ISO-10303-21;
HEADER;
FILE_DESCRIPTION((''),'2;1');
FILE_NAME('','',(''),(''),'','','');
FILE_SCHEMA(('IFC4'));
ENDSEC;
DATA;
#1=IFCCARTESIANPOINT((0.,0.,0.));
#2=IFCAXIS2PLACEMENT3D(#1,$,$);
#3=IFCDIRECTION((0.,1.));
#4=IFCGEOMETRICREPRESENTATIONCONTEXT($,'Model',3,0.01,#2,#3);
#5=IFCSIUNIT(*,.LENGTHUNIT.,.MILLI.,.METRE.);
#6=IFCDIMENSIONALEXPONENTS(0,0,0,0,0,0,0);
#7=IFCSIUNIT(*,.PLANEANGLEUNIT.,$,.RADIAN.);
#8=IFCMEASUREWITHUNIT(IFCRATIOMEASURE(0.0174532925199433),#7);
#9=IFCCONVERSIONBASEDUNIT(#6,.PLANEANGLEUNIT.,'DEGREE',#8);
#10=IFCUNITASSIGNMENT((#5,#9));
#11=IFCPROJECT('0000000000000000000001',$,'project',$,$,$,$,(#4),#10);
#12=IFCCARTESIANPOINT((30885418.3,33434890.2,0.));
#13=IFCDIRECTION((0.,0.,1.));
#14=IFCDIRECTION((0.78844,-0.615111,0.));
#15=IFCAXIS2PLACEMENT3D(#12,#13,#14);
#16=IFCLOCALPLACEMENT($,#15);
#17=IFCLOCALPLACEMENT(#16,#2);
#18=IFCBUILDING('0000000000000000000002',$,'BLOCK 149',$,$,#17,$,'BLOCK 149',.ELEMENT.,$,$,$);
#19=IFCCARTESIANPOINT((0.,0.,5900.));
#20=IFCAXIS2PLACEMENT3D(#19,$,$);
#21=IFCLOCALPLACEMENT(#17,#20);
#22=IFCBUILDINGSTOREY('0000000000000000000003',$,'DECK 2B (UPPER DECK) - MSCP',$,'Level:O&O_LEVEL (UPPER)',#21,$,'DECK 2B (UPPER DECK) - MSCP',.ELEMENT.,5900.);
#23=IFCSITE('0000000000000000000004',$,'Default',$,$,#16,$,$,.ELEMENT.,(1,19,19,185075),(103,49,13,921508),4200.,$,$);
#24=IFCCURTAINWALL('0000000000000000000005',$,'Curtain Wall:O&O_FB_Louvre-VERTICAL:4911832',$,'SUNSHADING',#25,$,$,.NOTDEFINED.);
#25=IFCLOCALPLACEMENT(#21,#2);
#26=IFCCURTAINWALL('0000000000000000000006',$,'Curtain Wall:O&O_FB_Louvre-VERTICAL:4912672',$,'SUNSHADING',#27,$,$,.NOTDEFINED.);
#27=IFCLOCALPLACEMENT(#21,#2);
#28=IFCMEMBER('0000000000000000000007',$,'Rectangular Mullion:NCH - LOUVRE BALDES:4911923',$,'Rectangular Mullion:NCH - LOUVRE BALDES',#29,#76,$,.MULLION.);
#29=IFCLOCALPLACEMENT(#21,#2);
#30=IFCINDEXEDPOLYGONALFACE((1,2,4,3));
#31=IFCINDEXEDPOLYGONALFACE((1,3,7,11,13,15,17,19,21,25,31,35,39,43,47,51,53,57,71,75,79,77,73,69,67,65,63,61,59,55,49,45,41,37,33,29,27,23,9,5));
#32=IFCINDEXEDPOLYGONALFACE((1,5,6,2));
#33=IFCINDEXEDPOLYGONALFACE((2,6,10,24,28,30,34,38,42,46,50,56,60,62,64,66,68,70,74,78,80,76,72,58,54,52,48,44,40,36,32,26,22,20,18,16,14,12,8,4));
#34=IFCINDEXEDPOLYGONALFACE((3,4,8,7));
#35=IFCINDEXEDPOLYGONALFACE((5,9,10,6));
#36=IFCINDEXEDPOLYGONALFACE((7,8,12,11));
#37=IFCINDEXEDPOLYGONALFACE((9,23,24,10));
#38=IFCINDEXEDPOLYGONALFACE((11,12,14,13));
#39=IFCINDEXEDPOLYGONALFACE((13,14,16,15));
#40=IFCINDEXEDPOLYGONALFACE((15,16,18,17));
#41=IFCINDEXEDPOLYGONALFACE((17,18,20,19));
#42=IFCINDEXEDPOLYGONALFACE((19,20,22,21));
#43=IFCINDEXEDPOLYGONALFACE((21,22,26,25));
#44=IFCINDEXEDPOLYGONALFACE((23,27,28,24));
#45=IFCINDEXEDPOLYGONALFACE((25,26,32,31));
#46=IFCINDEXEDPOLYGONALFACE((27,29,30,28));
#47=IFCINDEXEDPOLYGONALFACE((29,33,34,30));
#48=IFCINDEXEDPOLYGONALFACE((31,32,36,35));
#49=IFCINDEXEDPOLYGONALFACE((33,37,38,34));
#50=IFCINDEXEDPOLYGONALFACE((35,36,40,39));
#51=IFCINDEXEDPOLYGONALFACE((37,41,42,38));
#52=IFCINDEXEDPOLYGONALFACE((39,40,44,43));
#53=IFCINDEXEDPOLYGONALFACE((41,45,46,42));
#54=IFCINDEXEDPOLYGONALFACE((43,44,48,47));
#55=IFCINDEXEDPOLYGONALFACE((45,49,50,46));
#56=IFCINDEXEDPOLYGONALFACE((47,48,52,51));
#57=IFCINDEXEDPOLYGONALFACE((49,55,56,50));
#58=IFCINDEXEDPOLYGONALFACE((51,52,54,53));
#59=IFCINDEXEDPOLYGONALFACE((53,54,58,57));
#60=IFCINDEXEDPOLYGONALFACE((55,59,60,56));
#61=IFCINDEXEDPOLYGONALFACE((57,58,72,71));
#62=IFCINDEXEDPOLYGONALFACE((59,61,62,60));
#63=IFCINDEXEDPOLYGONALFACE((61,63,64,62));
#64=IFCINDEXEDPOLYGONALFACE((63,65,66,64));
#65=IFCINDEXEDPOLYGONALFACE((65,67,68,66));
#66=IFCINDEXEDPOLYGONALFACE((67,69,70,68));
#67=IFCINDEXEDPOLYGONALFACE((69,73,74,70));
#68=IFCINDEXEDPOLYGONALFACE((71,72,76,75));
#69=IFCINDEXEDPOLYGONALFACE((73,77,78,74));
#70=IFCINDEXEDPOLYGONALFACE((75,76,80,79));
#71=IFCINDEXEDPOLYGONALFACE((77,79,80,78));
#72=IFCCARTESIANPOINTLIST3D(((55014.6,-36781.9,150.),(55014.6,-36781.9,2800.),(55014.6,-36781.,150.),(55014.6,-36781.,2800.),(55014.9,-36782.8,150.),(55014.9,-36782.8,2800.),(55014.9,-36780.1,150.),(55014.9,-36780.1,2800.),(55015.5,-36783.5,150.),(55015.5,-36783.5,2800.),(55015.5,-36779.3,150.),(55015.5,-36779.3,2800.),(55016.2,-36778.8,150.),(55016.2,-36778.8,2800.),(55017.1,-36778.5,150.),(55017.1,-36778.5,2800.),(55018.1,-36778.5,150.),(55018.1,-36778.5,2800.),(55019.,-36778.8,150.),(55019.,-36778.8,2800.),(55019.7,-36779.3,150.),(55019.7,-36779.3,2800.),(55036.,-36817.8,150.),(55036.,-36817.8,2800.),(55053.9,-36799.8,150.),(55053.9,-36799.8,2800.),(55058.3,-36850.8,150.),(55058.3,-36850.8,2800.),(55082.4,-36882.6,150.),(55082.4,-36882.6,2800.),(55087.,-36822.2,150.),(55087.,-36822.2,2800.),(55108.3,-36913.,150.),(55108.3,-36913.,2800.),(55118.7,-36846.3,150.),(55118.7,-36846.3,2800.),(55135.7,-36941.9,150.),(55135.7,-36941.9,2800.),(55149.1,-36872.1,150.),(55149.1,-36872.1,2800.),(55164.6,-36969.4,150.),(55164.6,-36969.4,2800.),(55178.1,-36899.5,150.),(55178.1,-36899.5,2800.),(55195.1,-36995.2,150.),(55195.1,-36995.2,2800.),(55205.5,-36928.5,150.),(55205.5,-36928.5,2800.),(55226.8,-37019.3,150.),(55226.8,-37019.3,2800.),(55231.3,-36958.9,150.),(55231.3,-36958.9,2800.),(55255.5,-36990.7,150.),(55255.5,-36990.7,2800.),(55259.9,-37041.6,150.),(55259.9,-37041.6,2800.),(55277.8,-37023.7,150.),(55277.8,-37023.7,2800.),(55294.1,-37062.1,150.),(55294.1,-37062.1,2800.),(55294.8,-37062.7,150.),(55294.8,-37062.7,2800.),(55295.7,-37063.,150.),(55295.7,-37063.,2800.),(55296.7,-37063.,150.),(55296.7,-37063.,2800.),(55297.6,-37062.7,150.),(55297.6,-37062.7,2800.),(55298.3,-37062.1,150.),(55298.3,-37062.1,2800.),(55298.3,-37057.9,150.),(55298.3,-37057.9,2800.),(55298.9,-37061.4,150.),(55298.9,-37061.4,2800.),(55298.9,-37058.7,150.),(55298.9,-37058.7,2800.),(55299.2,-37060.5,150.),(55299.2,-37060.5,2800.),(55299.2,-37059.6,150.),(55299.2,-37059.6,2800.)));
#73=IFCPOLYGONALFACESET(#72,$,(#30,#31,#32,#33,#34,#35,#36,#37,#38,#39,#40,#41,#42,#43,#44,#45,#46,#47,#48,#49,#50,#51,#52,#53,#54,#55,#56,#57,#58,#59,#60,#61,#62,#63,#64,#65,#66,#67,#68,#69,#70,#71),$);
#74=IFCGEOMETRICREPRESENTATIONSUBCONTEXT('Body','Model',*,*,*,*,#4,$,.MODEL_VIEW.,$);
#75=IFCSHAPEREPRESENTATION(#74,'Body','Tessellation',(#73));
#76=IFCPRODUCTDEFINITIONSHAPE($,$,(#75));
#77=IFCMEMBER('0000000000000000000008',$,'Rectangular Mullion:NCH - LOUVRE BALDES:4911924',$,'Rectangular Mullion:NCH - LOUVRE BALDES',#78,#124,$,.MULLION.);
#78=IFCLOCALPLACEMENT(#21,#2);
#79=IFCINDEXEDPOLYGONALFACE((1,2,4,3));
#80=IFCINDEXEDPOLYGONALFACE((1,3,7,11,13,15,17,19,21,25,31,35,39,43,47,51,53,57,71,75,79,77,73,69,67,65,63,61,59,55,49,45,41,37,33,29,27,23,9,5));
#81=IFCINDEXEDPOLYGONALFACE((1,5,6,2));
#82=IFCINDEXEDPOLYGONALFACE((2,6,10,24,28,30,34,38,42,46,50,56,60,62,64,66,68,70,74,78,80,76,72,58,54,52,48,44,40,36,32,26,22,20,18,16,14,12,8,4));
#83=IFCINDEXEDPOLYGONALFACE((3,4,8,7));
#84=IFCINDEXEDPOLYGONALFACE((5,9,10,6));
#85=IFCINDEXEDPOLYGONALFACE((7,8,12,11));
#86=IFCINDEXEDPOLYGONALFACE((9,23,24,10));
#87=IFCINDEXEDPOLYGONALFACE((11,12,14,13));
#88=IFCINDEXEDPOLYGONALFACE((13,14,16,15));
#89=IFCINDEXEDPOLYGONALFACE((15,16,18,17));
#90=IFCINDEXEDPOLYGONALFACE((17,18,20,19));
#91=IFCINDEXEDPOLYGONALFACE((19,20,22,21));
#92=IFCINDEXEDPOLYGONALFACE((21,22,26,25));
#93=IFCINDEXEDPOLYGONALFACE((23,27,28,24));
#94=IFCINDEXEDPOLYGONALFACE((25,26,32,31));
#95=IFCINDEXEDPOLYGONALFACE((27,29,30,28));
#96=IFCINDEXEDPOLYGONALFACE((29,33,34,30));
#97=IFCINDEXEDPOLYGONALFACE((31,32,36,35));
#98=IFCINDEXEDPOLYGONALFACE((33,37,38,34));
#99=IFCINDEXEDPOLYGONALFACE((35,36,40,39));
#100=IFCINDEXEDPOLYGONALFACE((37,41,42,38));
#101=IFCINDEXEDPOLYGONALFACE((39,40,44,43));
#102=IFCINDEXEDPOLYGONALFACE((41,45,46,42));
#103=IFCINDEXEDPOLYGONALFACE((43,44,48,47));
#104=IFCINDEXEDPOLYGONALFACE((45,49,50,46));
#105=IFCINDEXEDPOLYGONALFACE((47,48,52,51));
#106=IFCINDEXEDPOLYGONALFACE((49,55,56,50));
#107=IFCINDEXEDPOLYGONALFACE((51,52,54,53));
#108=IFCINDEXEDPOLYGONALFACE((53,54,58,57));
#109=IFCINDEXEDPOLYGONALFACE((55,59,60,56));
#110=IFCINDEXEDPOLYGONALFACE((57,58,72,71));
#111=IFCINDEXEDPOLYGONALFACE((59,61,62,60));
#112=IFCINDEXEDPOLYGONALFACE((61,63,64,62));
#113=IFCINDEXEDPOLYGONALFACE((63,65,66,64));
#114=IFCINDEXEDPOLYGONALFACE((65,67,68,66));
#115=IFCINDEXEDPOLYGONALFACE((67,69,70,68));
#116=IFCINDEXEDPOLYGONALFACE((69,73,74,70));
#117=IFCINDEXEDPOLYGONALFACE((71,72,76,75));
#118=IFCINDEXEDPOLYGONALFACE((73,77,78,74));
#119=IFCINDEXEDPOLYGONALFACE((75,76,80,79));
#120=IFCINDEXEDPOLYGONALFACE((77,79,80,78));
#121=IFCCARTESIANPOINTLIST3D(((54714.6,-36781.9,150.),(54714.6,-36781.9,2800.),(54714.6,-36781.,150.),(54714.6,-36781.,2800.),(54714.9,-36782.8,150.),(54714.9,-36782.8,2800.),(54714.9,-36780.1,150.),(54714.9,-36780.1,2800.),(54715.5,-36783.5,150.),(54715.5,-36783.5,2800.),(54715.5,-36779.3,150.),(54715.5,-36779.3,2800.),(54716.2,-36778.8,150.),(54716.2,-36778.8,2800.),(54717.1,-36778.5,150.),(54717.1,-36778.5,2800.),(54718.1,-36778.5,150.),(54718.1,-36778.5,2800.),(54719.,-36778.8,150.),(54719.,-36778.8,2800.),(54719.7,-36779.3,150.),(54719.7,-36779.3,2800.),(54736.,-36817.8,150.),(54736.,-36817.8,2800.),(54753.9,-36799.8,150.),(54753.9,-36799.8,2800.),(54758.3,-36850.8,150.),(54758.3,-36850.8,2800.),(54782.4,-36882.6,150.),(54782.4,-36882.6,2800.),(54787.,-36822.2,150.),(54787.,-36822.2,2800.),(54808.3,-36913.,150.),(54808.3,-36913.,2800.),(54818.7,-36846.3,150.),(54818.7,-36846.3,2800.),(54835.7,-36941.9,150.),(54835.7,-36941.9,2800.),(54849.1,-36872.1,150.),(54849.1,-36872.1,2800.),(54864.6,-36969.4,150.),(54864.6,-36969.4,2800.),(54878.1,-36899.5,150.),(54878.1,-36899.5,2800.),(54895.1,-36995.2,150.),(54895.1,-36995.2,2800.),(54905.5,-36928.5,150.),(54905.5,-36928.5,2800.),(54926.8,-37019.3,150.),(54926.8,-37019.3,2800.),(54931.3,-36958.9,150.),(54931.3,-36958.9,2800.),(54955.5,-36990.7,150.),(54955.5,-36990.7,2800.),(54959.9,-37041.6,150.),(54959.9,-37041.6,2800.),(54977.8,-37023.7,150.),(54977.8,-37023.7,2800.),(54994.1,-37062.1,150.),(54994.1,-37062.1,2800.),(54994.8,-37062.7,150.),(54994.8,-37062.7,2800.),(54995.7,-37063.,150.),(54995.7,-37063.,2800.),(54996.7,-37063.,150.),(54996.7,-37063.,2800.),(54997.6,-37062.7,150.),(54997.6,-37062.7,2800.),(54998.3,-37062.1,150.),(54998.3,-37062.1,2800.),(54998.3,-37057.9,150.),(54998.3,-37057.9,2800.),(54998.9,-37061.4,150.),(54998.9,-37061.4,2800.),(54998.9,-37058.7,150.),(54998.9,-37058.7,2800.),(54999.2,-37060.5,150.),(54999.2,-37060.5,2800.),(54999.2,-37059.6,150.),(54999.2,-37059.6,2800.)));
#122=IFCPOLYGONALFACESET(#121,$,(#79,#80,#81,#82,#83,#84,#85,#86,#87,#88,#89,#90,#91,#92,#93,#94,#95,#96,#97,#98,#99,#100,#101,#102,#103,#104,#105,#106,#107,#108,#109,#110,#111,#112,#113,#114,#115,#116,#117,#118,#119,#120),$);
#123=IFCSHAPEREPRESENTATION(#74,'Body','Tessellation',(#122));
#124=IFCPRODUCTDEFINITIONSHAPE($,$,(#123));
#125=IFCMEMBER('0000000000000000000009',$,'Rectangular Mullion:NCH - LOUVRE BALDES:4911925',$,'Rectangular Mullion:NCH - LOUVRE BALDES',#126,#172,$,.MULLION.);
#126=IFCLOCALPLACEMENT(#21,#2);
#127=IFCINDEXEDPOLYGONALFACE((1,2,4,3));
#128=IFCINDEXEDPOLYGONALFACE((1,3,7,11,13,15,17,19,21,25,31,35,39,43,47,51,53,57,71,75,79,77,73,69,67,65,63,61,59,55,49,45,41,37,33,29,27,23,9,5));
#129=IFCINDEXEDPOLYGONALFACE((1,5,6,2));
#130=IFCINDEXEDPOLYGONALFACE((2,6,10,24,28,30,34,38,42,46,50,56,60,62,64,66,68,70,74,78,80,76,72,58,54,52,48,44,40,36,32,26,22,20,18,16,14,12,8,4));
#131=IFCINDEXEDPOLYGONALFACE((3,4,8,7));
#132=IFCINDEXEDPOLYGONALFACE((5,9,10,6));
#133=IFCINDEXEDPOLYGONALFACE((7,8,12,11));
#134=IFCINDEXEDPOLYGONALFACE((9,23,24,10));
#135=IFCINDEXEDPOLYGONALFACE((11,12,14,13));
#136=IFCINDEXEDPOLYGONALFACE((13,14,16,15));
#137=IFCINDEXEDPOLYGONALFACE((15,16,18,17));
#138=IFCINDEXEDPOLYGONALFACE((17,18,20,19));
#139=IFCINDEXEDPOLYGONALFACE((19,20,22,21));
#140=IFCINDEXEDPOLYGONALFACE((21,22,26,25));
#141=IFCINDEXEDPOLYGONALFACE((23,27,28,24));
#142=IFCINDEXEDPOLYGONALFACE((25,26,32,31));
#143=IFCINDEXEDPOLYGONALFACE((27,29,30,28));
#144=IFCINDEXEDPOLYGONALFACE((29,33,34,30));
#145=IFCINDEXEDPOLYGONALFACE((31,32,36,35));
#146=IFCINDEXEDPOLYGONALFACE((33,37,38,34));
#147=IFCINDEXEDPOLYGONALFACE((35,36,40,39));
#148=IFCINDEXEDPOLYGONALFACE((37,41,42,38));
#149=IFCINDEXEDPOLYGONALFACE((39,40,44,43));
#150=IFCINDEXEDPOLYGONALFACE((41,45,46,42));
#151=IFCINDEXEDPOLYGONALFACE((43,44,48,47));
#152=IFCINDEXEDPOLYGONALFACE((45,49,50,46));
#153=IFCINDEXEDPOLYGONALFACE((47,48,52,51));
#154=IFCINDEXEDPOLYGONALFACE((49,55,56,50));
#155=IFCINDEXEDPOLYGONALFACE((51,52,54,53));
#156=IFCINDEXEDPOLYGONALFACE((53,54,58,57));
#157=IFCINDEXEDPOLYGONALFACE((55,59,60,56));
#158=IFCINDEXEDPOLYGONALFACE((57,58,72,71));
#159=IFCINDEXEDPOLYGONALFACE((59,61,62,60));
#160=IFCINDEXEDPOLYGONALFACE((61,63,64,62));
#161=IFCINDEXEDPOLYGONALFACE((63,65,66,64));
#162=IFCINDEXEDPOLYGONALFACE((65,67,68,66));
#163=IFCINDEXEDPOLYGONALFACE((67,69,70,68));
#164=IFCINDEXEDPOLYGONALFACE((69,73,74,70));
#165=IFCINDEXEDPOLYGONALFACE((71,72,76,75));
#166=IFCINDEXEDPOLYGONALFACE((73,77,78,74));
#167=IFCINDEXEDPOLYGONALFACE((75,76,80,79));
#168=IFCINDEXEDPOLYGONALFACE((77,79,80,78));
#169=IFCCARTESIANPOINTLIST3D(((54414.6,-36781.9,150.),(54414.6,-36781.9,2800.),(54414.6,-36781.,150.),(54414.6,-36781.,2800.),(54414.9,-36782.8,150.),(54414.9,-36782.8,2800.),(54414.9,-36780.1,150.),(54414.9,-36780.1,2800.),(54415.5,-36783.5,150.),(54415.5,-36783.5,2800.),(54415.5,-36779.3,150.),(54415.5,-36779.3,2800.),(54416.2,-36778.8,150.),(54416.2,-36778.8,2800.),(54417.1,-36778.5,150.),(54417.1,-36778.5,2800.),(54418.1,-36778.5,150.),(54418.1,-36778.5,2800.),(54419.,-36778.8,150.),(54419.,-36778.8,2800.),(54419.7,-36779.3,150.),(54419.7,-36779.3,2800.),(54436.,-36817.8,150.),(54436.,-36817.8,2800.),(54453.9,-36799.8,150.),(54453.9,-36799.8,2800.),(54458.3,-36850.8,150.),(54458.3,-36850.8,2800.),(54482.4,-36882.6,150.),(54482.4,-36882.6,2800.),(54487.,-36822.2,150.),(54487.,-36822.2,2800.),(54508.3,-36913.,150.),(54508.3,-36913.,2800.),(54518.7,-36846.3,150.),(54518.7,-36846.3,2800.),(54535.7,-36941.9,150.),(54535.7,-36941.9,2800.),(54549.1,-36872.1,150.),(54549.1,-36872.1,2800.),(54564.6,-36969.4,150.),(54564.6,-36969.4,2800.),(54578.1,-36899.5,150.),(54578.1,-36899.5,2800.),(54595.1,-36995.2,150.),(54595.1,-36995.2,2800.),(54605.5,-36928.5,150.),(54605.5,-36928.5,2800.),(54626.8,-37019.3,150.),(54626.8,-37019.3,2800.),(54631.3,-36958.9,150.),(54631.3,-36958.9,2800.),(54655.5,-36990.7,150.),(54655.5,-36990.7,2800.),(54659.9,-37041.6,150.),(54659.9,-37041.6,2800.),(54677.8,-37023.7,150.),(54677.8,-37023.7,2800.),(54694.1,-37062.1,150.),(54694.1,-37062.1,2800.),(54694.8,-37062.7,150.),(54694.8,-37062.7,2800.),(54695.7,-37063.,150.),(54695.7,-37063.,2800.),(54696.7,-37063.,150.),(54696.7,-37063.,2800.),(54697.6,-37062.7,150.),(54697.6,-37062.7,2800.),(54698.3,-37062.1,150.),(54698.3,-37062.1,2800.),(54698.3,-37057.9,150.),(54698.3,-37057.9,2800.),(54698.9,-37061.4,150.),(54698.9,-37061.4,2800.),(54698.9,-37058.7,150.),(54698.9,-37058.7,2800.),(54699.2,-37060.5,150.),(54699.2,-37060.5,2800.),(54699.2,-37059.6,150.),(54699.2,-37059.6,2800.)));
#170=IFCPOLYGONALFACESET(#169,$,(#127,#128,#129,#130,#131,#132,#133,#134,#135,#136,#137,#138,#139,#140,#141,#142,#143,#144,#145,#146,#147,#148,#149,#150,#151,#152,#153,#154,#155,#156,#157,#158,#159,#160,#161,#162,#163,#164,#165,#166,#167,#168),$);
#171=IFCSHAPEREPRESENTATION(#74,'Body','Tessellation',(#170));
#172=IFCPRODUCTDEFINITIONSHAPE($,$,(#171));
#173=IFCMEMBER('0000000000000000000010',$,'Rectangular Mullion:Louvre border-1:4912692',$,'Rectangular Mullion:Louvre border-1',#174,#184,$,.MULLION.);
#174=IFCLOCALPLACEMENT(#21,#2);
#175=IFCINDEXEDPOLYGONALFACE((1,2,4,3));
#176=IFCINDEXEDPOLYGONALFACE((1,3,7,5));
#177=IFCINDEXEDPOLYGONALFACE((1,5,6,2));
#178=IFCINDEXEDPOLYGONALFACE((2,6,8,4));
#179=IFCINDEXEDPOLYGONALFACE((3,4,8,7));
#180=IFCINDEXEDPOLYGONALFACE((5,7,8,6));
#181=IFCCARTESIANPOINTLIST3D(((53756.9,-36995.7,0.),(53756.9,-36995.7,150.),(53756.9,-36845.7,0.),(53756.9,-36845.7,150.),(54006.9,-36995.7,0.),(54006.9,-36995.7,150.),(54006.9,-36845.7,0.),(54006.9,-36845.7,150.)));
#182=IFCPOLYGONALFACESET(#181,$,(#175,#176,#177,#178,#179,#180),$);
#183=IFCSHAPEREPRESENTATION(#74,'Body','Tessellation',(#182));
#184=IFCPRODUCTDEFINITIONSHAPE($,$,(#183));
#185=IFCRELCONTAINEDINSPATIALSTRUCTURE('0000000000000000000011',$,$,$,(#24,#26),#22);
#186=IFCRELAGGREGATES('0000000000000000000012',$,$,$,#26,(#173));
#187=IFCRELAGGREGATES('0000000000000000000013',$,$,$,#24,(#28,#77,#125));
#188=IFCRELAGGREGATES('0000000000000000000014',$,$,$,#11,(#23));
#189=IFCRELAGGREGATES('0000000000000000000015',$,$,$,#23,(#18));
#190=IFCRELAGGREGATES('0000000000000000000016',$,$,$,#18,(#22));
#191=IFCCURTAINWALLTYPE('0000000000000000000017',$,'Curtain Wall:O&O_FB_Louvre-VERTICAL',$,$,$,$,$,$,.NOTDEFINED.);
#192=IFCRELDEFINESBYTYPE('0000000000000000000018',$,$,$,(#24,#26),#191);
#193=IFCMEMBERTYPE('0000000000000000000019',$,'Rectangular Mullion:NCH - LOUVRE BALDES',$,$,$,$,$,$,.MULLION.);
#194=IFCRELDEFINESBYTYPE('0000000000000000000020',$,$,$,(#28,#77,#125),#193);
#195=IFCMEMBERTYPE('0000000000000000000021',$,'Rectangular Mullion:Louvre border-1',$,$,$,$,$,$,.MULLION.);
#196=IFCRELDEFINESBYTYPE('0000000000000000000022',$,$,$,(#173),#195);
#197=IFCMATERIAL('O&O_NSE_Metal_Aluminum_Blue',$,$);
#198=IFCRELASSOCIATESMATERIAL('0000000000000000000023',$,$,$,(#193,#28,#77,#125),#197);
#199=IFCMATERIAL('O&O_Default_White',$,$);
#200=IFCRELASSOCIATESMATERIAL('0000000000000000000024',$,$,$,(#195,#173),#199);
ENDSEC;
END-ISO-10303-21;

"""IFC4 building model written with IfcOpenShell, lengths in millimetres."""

from ifc_helpers import new_model, entity, si_unit, converted_unit, direction, frame, origin, place, context, subcontext, project, spatial, indexed_curve, outline, extrude, source, transform, mapped, material, type_object, type_shapes, element, aggregate, save


model = new_model("IFC4")

# Units and contexts
model_context = context("Model", 3, precision=0.01, world=origin(), true_north=direction((0.0, 1.0)))
body_context = subcontext(model_context, "Body", "Model", "MODEL_VIEW")
ifc_project = project(units=[si_unit("LENGTHUNIT", "METRE", prefix="MILLI"), converted_unit("PLANEANGLEUNIT", "DEGREE", entity("IfcRatioMeasure", 0.0174532925199433), si_unit("PLANEANGLEUNIT", "RADIAN"), dimensions=[0, 0, 0, 0, 0, 0, 0])], contexts=[model_context])

# Site, building, storey
site_placement = place(None, frame((30885418.3, 33434890.2, 0.0), z_axis=(0.0, 0.0, 1.0), x_axis=(0.78844, -0.615111, 0.0)))
site = spatial("IfcSite", under=ifc_project, at=site_placement, Name="Default", CompositionType="ELEMENT", RefLatitude=(1, 19, 19, 185075), RefLongitude=(103, 49, 13, 921508), RefElevation=4200.0)
building_placement = place(site_placement, origin())
building = spatial("IfcBuilding", under=site, at=building_placement, Name="BLOCK 149", LongName="BLOCK 149", CompositionType="ELEMENT")
storey_placement = place(building_placement, frame((0.0, 0.0, 5900.0)))
storey = spatial("IfcBuildingStorey", under=building, at=storey_placement, Name="DECK 2B (UPPER DECK) - MSCP", ObjectType="Level:O&O_LEVEL (UPPER)", LongName="DECK 2B (UPPER DECK) - MSCP", CompositionType="ELEMENT", Elevation=5900.0)

# Curtain walls
curtain_wall_type = type_object("IfcCurtainWallType", Name="Curtain Wall:O&O_FB_Louvre-VERTICAL", PredefinedType="NOTDEFINED")
curtain_wall_1_placement = place(storey_placement, frame((0.0, 0.0, -5900.0)))
curtain_wall_1 = element("IfcCurtainWall", 1, at=curtain_wall_1_placement, inside=storey, type_object=curtain_wall_type, Name="Curtain Wall:O&O_FB_Louvre-VERTICAL:4911832", ObjectType="SUNSHADING", PredefinedType="NOTDEFINED")
ifc_material_1 = material(Name="O&O_Default_White")
placement = place(building_placement, origin())
curtain_wall_2_placement = place(storey_placement, frame((0.0, 0.0, -5900.0)))
curtain_wall_2 = element("IfcCurtainWall", 2, at=curtain_wall_2_placement, inside=storey, type_object=curtain_wall_type, Name="Curtain Wall:O&O_FB_Louvre-VERTICAL:4912672", ObjectType="SUNSHADING", PredefinedType="NOTDEFINED")

# Members
ifc_material_2 = material(Name="O&O_NSE_Metal_Aluminum_Blue")
member_type_1 = type_object("IfcMemberType", Name="Rectangular Mullion:NCH - LOUVRE BALDES", PredefinedType="MULLION", material=ifc_material_2)
shared_shape_1 = source(origin(), body_context, "Body", "SweptSolid", [
    extrude(outline(indexed_curve([(55.9, -188.9), (54.8, -149.1), (51.6, -109.3), (46.1, -69.8), (38.6, -30.6), (28.9, 8.1), (17.1, 46.2), (3.3, 83.6), (-12.6, 120.2), (-30.4, 155.9), (-50.1, 190.5), (-50.5, 191.4), (-51.1, 192.1), (-52.0, 192.5), (-52.9, 192.7), (-53.8, 192.6), (-54.7, 192.2), (-55.4, 191.6), (-55.8, 190.8), (-56.0, 189.9), (-55.9, 188.9), (-54.8, 149.1), (-51.6, 109.3), (-46.1, 69.8), (-38.6, 30.6), (-28.9, -8.1), (-17.1, -46.2), (-3.3, -83.6), (12.6, -120.2), (30.4, -155.9), (50.1, -190.5), (50.5, -191.4), (51.1, -192.1), (52.0, -192.5), (52.9, -192.7), (53.8, -192.6), (54.7, -192.2), (55.4, -191.6), (55.8, -190.8), (56.0, -189.9), (55.9, -188.9)], self_intersect=False)), frame((0.0, 0.0, -2650.0), z_axis=(0.0, 0.0, 1.0), x_axis=(0.490779, -0.871284, 0.0)), (0.0, 0.0, 1.0), 2650.0),
])
type_shapes(member_type_1, [shared_shape_1])
member_1_placement = place(placement, frame((55156.9, -36920.7, 6050.0), z_axis=(0.0, 0.0, -1.0), x_axis=(-1.0, 0.0, 0.0)))
member_1 = element("IfcMember", 3, at=member_1_placement, type_object=member_type_1, material=ifc_material_2, Name="Rectangular Mullion:NCH - LOUVRE BALDES:4911923", ObjectType="Rectangular Mullion:NCH - LOUVRE BALDES", PredefinedType="MULLION", context=body_context, shape_type="MappedRepresentation", body=[
    mapped(shared_shape_1, transform((0.0, 0.0, 0.0), scale=1.0)),
])
member_2_placement = place(placement, frame((54856.9, -36920.7, 6050.0), z_axis=(0.0, 0.0, -1.0), x_axis=(-1.0, 0.0, 0.0)))
member_2 = element("IfcMember", 4, at=member_2_placement, type_object=member_type_1, material=ifc_material_2, Name="Rectangular Mullion:NCH - LOUVRE BALDES:4911924", ObjectType="Rectangular Mullion:NCH - LOUVRE BALDES", PredefinedType="MULLION", context=body_context, shape_type="MappedRepresentation", body=[
    mapped(shared_shape_1, transform((0.0, 0.0, 0.0), scale=1.0)),
])
member_3_placement = place(placement, frame((54556.9, -36920.7, 6050.0), z_axis=(0.0, 0.0, -1.0), x_axis=(-1.0, 0.0, 0.0)))
member_3 = element("IfcMember", 5, at=member_3_placement, type_object=member_type_1, material=ifc_material_2, Name="Rectangular Mullion:NCH - LOUVRE BALDES:4911925", ObjectType="Rectangular Mullion:NCH - LOUVRE BALDES", PredefinedType="MULLION", context=body_context, shape_type="MappedRepresentation", body=[
    mapped(shared_shape_1, transform((0.0, 0.0, 0.0), scale=1.0)),
])
member_type_2 = type_object("IfcMemberType", Name="Rectangular Mullion:Louvre border-1", PredefinedType="MULLION", material=ifc_material_1)
shared_shape_2 = source(origin(), body_context, "Body", "SweptSolid", [
    extrude(outline(indexed_curve([(-75.0, -75.0), (75.0, -75.0), (75.0, 75.0), (-75.0, 75.0), (-75.0, -75.0)], self_intersect=False)), frame((-75.0, 0.0, -250.0), z_axis=(0.0, 0.0, 1.0), x_axis=(0.0, -1.0, 0.0)), (0.0, 0.0, 1.0), 250.0),
])
type_shapes(member_type_2, [shared_shape_2])
member_4_placement = place(placement, frame((54006.9, -36920.7, 5900.0), z_axis=(1.0, 0.0, 0.0), x_axis=(0.0, 0.0, -1.0)))
member_4 = element("IfcMember", 6, at=member_4_placement, type_object=member_type_2, material=ifc_material_1, Name="Rectangular Mullion:Louvre border-1:4912692", ObjectType="Rectangular Mullion:Louvre border-1", PredefinedType="MULLION", context=body_context, shape_type="MappedRepresentation", body=[
    mapped(shared_shape_2, transform((0.0, 0.0, 0.0), scale=1.0)),
])
aggregate(curtain_wall_2, [member_4])
aggregate(curtain_wall_1, [member_1, member_2, member_3])

save(model, "model.ifc")
